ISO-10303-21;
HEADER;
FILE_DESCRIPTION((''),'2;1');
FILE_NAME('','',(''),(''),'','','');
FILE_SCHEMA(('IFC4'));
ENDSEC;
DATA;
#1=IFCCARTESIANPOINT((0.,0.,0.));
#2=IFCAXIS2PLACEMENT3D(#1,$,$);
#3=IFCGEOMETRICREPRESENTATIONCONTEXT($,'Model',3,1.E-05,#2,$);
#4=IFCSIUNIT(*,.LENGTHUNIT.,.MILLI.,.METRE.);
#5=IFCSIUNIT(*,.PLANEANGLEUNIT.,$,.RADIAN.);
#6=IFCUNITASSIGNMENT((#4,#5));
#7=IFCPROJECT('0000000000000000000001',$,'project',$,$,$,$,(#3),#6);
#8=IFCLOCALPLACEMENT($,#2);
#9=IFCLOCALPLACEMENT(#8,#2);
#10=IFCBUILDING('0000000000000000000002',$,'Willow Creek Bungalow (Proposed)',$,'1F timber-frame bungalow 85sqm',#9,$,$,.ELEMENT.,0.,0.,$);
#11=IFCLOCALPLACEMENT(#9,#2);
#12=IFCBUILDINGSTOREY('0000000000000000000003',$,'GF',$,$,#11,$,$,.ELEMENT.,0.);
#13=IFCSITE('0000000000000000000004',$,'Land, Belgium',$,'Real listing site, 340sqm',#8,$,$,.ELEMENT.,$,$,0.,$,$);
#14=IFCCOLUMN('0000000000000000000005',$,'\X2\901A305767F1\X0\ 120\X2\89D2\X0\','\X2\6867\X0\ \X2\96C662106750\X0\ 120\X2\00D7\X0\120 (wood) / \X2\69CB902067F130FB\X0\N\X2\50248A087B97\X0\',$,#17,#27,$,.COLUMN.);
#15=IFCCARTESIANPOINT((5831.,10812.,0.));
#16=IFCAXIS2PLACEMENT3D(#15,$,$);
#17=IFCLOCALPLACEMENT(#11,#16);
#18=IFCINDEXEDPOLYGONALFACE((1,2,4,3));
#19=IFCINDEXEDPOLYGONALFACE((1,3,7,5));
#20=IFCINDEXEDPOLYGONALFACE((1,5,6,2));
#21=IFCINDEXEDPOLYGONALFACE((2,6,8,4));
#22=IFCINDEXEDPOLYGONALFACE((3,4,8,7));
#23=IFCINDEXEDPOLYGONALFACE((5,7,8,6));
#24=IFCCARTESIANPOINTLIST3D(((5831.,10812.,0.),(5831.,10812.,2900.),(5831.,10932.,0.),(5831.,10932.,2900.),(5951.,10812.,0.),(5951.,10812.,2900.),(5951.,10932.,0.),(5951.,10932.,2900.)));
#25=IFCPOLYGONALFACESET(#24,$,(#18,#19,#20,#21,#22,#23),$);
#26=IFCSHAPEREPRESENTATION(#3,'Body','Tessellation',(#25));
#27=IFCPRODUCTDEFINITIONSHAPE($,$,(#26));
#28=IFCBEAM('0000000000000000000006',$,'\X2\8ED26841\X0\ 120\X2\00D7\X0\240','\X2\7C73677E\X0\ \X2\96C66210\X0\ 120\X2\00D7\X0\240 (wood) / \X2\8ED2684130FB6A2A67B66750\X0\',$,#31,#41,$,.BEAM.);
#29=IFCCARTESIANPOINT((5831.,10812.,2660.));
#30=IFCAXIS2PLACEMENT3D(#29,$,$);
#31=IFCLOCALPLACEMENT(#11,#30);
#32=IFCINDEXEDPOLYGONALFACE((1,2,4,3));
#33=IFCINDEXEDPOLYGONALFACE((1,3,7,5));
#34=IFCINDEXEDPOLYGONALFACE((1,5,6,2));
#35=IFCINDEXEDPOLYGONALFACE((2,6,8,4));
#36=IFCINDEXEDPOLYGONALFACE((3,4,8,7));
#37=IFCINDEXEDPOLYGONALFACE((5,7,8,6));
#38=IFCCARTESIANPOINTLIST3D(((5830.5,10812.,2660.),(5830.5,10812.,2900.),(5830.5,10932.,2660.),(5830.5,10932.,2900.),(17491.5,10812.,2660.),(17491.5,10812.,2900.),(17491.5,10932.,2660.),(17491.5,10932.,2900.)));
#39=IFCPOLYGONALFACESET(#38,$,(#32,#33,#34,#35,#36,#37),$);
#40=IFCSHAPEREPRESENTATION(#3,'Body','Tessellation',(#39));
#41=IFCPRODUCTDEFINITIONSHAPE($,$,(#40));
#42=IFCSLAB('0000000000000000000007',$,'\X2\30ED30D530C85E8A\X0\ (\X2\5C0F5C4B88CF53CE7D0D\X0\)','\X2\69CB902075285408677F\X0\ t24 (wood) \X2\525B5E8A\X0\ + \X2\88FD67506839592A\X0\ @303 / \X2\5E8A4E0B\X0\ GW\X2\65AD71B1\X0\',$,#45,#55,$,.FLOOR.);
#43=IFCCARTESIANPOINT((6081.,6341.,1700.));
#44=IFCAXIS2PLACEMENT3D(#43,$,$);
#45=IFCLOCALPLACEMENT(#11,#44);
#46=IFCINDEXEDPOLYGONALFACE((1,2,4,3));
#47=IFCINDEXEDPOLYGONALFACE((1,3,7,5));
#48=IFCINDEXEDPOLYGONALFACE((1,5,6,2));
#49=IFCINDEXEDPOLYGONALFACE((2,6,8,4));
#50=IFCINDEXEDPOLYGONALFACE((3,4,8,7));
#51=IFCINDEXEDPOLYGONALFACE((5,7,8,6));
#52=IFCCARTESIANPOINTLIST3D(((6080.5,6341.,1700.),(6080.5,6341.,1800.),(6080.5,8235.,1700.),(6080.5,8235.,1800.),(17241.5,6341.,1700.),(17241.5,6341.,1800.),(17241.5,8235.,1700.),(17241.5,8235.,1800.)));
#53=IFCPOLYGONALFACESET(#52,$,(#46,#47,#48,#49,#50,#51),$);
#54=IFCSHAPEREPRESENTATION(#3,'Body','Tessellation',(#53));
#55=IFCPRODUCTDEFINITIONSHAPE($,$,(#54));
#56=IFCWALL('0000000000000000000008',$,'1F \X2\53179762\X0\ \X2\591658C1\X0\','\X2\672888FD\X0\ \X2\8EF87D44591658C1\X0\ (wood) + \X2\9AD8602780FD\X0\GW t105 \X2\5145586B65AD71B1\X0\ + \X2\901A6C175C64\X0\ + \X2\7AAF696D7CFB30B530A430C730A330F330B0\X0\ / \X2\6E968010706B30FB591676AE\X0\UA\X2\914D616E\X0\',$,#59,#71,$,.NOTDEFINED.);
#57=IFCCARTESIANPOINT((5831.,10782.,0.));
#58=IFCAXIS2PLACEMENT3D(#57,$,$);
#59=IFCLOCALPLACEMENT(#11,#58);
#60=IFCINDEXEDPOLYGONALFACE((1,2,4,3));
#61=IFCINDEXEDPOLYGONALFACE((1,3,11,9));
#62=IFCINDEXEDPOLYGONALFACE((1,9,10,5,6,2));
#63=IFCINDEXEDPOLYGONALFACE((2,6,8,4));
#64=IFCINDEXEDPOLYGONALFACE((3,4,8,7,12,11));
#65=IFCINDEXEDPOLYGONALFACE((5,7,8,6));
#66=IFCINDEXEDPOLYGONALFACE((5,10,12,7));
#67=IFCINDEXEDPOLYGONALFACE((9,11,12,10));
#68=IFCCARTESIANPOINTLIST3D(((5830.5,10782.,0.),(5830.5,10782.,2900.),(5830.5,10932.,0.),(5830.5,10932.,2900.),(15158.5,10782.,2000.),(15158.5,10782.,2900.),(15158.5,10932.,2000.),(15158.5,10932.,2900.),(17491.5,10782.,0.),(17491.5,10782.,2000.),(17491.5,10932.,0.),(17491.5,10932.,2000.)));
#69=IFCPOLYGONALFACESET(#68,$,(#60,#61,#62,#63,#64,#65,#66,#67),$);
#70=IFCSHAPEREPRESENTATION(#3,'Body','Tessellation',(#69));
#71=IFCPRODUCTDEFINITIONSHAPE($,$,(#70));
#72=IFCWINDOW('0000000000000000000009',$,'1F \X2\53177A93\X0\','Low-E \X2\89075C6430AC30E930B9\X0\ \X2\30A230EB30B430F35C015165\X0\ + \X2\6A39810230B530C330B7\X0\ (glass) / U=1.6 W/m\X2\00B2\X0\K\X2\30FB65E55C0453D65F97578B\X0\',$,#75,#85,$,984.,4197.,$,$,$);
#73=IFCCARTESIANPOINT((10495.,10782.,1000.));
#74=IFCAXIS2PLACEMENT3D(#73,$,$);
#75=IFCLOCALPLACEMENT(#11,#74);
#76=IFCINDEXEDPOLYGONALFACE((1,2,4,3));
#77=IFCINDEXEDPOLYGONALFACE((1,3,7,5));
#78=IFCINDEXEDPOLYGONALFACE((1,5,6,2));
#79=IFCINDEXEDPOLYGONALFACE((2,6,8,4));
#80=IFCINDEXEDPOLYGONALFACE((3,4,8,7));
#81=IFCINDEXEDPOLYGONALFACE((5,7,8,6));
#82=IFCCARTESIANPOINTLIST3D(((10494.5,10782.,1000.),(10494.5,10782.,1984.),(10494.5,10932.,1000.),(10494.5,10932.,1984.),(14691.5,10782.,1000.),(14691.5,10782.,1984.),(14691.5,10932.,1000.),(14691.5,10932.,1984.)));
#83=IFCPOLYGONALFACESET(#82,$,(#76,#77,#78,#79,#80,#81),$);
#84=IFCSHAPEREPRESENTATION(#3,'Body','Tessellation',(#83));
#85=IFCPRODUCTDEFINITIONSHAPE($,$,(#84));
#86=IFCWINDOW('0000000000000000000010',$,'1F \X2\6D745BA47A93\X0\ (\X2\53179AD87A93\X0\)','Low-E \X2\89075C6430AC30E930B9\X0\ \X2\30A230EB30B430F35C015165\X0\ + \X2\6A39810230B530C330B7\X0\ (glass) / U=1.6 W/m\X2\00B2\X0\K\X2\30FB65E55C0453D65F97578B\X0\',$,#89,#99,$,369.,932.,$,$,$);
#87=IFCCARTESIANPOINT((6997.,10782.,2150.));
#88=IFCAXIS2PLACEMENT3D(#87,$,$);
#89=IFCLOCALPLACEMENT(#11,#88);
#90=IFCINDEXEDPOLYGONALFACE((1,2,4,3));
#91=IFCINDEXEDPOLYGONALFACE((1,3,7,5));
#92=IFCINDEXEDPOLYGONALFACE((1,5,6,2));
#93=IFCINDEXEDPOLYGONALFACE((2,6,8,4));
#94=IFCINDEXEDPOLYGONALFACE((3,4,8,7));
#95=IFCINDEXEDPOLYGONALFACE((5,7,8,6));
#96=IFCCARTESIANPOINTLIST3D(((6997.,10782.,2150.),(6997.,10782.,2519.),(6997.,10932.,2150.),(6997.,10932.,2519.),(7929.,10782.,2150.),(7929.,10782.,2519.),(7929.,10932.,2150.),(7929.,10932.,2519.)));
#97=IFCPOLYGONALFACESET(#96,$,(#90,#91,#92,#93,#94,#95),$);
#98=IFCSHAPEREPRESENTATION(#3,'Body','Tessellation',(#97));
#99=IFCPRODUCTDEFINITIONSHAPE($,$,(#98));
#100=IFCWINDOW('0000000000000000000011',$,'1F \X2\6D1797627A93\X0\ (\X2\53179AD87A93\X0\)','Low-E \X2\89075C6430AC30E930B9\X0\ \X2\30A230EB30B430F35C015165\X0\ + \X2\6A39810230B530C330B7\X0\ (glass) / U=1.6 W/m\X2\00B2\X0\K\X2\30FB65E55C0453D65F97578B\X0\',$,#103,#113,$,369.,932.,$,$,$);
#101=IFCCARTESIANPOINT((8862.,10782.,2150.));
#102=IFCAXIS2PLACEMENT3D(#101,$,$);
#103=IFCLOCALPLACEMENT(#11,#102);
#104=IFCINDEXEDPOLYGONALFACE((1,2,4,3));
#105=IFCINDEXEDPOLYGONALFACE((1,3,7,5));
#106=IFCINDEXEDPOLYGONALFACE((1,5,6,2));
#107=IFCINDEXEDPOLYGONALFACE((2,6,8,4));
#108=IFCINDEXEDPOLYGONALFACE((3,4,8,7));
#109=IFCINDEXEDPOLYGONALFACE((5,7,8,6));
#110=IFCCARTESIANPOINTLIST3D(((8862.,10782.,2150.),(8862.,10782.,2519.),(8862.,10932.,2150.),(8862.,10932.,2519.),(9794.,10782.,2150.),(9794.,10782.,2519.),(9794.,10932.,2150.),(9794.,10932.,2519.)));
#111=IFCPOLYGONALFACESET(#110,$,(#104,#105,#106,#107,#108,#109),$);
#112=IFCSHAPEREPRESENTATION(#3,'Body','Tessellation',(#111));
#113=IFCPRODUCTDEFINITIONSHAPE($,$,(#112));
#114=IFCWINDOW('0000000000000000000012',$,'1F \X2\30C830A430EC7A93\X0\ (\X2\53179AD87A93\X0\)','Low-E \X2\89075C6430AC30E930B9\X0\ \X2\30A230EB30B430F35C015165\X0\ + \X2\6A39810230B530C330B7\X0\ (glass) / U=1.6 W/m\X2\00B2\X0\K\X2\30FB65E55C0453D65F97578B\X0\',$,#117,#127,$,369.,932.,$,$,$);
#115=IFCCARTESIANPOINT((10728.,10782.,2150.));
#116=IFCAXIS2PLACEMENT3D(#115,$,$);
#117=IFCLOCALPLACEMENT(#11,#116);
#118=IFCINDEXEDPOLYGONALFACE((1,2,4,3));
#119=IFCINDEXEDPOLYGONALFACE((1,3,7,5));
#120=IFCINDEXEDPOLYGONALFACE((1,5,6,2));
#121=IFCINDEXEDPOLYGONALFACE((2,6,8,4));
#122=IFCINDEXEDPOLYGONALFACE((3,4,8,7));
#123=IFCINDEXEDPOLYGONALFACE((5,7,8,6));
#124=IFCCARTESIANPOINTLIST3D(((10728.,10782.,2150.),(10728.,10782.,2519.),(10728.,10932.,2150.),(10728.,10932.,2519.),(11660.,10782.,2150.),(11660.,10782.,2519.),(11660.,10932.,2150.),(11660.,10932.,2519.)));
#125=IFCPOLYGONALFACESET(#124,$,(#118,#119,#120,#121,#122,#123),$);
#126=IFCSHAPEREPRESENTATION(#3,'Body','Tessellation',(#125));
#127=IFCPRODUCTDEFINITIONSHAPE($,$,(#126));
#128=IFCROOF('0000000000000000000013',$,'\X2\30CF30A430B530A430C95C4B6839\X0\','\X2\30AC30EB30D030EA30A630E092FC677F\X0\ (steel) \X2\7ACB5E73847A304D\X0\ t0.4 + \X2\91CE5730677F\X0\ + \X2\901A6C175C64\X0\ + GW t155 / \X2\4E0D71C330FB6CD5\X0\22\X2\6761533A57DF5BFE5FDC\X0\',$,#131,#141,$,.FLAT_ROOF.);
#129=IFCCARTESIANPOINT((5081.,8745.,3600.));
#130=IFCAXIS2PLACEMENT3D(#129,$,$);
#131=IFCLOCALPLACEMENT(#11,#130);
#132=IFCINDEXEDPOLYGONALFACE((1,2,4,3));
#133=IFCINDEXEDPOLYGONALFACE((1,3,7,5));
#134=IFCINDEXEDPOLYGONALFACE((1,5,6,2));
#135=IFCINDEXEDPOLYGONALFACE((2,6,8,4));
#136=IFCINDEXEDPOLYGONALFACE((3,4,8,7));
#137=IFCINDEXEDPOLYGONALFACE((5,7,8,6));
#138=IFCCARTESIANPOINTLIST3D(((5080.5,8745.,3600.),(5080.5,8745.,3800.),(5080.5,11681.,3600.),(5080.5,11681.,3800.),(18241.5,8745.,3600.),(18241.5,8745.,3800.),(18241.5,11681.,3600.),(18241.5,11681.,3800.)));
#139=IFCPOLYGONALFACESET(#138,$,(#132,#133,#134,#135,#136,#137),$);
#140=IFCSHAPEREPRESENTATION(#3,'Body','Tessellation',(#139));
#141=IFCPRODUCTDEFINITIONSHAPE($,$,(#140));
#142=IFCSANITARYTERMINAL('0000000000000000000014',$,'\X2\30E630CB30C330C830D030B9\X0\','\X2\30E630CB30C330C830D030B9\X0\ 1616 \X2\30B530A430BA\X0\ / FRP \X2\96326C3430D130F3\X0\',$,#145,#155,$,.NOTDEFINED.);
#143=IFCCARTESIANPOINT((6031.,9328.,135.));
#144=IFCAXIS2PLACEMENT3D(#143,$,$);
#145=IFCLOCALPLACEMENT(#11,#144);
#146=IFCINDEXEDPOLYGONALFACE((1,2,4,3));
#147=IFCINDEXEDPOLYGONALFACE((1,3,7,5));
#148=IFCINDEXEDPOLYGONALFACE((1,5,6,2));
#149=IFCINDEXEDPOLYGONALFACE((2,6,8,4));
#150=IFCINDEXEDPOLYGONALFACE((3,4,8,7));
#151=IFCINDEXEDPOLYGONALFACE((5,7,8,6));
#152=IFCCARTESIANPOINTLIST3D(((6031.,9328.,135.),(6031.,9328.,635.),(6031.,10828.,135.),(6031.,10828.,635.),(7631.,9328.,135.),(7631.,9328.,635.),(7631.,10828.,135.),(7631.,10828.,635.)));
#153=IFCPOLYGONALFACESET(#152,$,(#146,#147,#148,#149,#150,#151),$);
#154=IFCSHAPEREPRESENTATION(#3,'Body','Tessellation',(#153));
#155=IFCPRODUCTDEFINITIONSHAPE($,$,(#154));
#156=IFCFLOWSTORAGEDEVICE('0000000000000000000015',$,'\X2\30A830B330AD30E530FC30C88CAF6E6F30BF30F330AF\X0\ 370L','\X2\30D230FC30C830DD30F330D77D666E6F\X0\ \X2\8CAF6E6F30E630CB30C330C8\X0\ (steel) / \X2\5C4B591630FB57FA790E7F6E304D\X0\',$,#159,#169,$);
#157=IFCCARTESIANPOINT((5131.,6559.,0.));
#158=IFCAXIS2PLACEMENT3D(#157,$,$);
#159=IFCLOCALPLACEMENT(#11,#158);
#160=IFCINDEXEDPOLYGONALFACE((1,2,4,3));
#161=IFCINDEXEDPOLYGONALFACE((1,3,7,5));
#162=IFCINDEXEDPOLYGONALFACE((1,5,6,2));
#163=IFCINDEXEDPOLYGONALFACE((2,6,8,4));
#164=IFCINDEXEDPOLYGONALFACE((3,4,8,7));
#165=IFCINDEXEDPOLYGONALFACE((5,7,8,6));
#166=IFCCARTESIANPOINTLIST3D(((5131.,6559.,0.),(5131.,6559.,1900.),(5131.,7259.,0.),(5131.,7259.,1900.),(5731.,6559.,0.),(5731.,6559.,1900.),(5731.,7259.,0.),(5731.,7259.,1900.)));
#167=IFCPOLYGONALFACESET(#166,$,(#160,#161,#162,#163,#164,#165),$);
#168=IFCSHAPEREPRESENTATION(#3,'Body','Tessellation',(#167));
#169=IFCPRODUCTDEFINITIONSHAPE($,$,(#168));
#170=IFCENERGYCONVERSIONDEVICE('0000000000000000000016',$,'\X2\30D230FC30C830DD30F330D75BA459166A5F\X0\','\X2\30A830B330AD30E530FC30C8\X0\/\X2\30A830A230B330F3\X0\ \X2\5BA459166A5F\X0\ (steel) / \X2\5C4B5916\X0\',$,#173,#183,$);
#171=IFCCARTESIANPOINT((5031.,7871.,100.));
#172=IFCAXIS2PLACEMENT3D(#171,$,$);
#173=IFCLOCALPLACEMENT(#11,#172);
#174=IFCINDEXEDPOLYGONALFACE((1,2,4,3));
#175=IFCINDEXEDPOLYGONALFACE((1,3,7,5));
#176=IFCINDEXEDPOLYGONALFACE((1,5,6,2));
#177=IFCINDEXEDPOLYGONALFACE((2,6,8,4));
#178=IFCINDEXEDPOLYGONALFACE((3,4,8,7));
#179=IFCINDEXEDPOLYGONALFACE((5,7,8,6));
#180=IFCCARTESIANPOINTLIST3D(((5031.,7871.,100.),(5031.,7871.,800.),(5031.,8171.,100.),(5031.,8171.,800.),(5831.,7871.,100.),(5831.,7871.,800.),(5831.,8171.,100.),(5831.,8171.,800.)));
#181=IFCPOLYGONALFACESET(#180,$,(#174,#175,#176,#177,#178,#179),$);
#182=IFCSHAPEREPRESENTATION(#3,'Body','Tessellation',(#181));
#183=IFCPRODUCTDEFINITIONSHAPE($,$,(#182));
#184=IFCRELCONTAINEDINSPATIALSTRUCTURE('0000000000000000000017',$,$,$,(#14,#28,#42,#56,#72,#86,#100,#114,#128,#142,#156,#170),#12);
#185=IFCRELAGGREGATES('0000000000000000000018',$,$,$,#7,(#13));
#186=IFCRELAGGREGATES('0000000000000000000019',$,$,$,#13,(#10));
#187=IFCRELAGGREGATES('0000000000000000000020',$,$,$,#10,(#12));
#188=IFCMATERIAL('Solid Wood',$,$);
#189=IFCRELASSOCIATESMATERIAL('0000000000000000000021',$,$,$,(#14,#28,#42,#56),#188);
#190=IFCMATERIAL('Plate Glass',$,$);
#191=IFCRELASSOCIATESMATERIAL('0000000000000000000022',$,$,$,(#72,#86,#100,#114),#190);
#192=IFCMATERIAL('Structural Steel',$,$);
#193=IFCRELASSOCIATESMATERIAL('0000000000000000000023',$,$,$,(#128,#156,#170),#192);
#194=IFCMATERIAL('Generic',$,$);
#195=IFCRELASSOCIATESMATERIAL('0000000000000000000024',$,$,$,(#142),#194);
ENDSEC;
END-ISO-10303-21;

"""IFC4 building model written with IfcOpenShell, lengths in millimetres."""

from ifc_helpers import new_model, si_unit, frame, frame_2d, origin, place, context, project, spatial, rectangle, extrude, material, element, fill, save


model = new_model("IFC4")

# Units and contexts
model_context = context("Model", 3, precision=1e-05, world=origin())
ifc_project = project(units=[si_unit("LENGTHUNIT", "METRE", prefix="MILLI"), si_unit("PLANEANGLEUNIT", "RADIAN")], contexts=[model_context])

# Site, building, storey
site_placement = place(None, origin())
site = spatial("IfcSite", under=ifc_project, at=site_placement, Name="Land, Belgium", ObjectType="Real listing site, 340sqm", CompositionType="ELEMENT", RefElevation=0.0)
building_placement = place(site_placement, origin())
building = spatial("IfcBuilding", under=site, at=building_placement, Name="Willow Creek Bungalow (Proposed)", ObjectType="1F timber-frame bungalow 85sqm", CompositionType="ELEMENT", ElevationOfRefHeight=0.0, ElevationOfTerrain=0.0)
storey_placement = place(building_placement, origin())
storey = spatial("IfcBuildingStorey", under=building, at=storey_placement, Name="GF", CompositionType="ELEMENT", Elevation=0.0)

# Column
ifc_material_1 = material(Name="Solid Wood")
column_1_placement = place(storey_placement, frame((5831.0, 10812.0, 0.0)))
element("IfcColumn", 1, at=column_1_placement, inside=storey, material=ifc_material_1, Name="通し柱 120角", Description="桧 集成材 120×120 (wood) / 構造柱・N値計算", PredefinedType="COLUMN", context=model_context, shape_type="SweptSolid", body=[
    extrude(rectangle(XDim=120.0, YDim=120.0, at=frame_2d((60.0, 60.0))), frame((5831.0, 10812.0, 0.0)), (0.0, 0.0, 1.0), 2900.0),
])

# Beam
beam_1_placement = place(storey_placement, frame((5831.0, 10812.0, 2660.0)))
element("IfcBeam", 2, at=beam_1_placement, inside=storey, material=ifc_material_1, Name="軒桁 120×240", Description="米松 集成 120×240 (wood) / 軒桁・横架材", PredefinedType="BEAM", context=model_context, shape_type="SweptSolid", body=[
    extrude(rectangle(XDim=11661.0, YDim=120.0, at=frame_2d((5830.0, 60.0))), frame((5831.0, 10812.0, 2660.0)), (0.0, 0.0, 1.0), 240.0),
])

# Slab
slab_placement = place(storey_placement, frame((6081.0, 6341.0, 1700.0)))
element("IfcSlab", 3, at=slab_placement, inside=storey, material=ifc_material_1, Name="ロフト床 (小屋裏収納)", Description="構造用合板 t24 (wood) 剛床 + 製材根太 @303 / 床下 GW断熱", PredefinedType="FLOOR", context=model_context, shape_type="SweptSolid", body=[
    extrude(rectangle(XDim=11161.0, YDim=1894.0, at=frame_2d((5580.0, 947.0))), frame((6081.0, 6341.0, 1700.0)), (0.0, 0.0, 1.0), 100.0),
])

# Wall, openings, windows
wall_1_placement = place(storey_placement, frame((5831.0, 10782.0, 0.0)))
wall_1 = element("IfcWall", 4, at=wall_1_placement, inside=storey, material=ifc_material_1, Name="1F 北面 外壁", Description="木製 軸組外壁 (wood) + 高性能GW t105 充填断熱 + 通気層 + 窯業系サイディング / 準耐火・外皮UA配慮", PredefinedType="NOTDEFINED", context=model_context, shape_type="SweptSolid", body=[
    extrude(rectangle(XDim=11661.0, YDim=150.0, at=frame_2d((5830.0, 75.0))), frame((5831.0, 10782.0, 0.0)), (0.0, 0.0, 1.0), 2900.0),
])
opening_1_placement = place(storey_placement, frame((10495.0, 10782.0, 1000.0)))
opening_1 = element("IfcOpeningElement", 5, at=opening_1_placement, cuts=wall_1, PredefinedType="NOTDEFINED", context=model_context, shape_type="SweptSolid", body=[
    extrude(rectangle(XDim=4197.0, YDim=150.0, at=frame_2d((2098.0, 75.0))), frame((10495.0, 10782.0, 1000.0)), (0.0, 0.0, 1.0), 984.0),
])
opening_2_placement = place(storey_placement, frame((6997.0, 10782.0, 2150.0)))
opening_2 = element("IfcOpeningElement", 6, at=opening_2_placement, cuts=wall_1, PredefinedType="NOTDEFINED", context=model_context, shape_type="SweptSolid", body=[
    extrude(rectangle(XDim=932.0, YDim=150.0, at=frame_2d((466.0, 75.0))), frame((6997.0, 10782.0, 2150.0)), (0.0, 0.0, 1.0), 369.0),
])
opening_3_placement = place(storey_placement, frame((8862.0, 10782.0, 2150.0)))
opening_3 = element("IfcOpeningElement", 7, at=opening_3_placement, cuts=wall_1, PredefinedType="NOTDEFINED", context=model_context, shape_type="SweptSolid", body=[
    extrude(rectangle(XDim=932.0, YDim=150.0, at=frame_2d((466.0, 75.0))), frame((8862.0, 10782.0, 2150.0)), (0.0, 0.0, 1.0), 369.0),
])
opening_4_placement = place(storey_placement, frame((10728.0, 10782.0, 2150.0)))
opening_4 = element("IfcOpeningElement", 8, at=opening_4_placement, cuts=wall_1, PredefinedType="NOTDEFINED", context=model_context, shape_type="SweptSolid", body=[
    extrude(rectangle(XDim=932.0, YDim=150.0, at=frame_2d((466.0, 75.0))), frame((10728.0, 10782.0, 2150.0)), (0.0, 0.0, 1.0), 369.0),
])
ifc_material_2 = material(Name="Plate Glass")
window_1_placement = place(storey_placement, frame((10495.0, 10782.0, 1000.0)))
window_1 = element("IfcWindow", 9, at=window_1_placement, inside=storey, material=ifc_material_2, Name="1F 北窓", Description="Low-E 複層ガラス アルゴン封入 + 樹脂サッシ (glass) / U=1.6 W/m²K・日射取得型", OverallHeight=984.0, OverallWidth=4197.0, context=model_context, shape_type="SweptSolid", body=[
    extrude(rectangle(XDim=4197.0, YDim=150.0, at=frame_2d((2098.0, 75.0))), frame((10495.0, 10782.0, 1000.0)), (0.0, 0.0, 1.0), 984.0),
])
fill(opening_1, window_1)
window_2_placement = place(storey_placement, frame((6997.0, 10782.0, 2150.0)))
window_2 = element("IfcWindow", 10, at=window_2_placement, inside=storey, material=ifc_material_2, Name="1F 浴室窓 (北高窓)", Description="Low-E 複層ガラス アルゴン封入 + 樹脂サッシ (glass) / U=1.6 W/m²K・日射取得型", OverallHeight=369.0, OverallWidth=932.0, context=model_context, shape_type="SweptSolid", body=[
    extrude(rectangle(XDim=932.0, YDim=150.0, at=frame_2d((466.0, 75.0))), frame((6997.0, 10782.0, 2150.0)), (0.0, 0.0, 1.0), 369.0),
])
fill(opening_2, window_2)
window_3_placement = place(storey_placement, frame((8862.0, 10782.0, 2150.0)))
window_3 = element("IfcWindow", 11, at=window_3_placement, inside=storey, material=ifc_material_2, Name="1F 洗面窓 (北高窓)", Description="Low-E 複層ガラス アルゴン封入 + 樹脂サッシ (glass) / U=1.6 W/m²K・日射取得型", OverallHeight=369.0, OverallWidth=932.0, context=model_context, shape_type="SweptSolid", body=[
    extrude(rectangle(XDim=932.0, YDim=150.0, at=frame_2d((466.0, 75.0))), frame((8862.0, 10782.0, 2150.0)), (0.0, 0.0, 1.0), 369.0),
])
fill(opening_3, window_3)
window_4_placement = place(storey_placement, frame((10728.0, 10782.0, 2150.0)))
window_4 = element("IfcWindow", 12, at=window_4_placement, inside=storey, material=ifc_material_2, Name="1F トイレ窓 (北高窓)", Description="Low-E 複層ガラス アルゴン封入 + 樹脂サッシ (glass) / U=1.6 W/m²K・日射取得型", OverallHeight=369.0, OverallWidth=932.0, context=model_context, shape_type="SweptSolid", body=[
    extrude(rectangle(XDim=932.0, YDim=150.0, at=frame_2d((466.0, 75.0))), frame((10728.0, 10782.0, 2150.0)), (0.0, 0.0, 1.0), 369.0),
])
fill(opening_4, window_4)

# Roof
ifc_material_3 = material(Name="Structural Steel")
roof_placement = place(storey_placement, frame((5081.0, 8745.0, 3600.0)))
element("IfcRoof", 13, at=roof_placement, inside=storey, material=ifc_material_3, Name="ハイサイド屋根", Description="ガルバリウム鋼板 (steel) 立平葺き t0.4 + 野地板 + 通気層 + GW t155 / 不燃・法22条区域対応", PredefinedType="FLAT_ROOF", context=model_context, shape_type="SweptSolid", body=[
    extrude(rectangle(XDim=13161.0, YDim=2936.0, at=frame_2d((6580.0, 1468.0))), frame((5081.0, 8745.0, 3600.0)), (0.0, 0.0, 1.0), 200.0),
])

# Sanitary terminal
ifc_material_4 = material(Name="Generic")
sanitary_terminal_placement = place(storey_placement, frame((6031.0, 9328.0, 135.0)))
element("IfcSanitaryTerminal", 14, at=sanitary_terminal_placement, inside=storey, material=ifc_material_4, Name="ユニットバス", Description="ユニットバス 1616 サイズ / FRP 防水パン", PredefinedType="NOTDEFINED", context=model_context, shape_type="SweptSolid", body=[
    extrude(rectangle(XDim=1600.0, YDim=1500.0, at=frame_2d((800.0, 750.0))), frame((6031.0, 9328.0, 135.0)), (0.0, 0.0, 1.0), 500.0),
])

# Flow storage device
flow_storage_device_placement = place(storey_placement, frame((5131.0, 6559.0, 0.0)))
element("IfcFlowStorageDevice", 15, at=flow_storage_device_placement, inside=storey, material=ifc_material_3, Name="エコキュート貯湯タンク 370L", Description="ヒートポンプ給湯 貯湯ユニット (steel) / 屋外・基礎置き", context=model_context, shape_type="SweptSolid", body=[
    extrude(rectangle(XDim=600.0, YDim=700.0, at=frame_2d((300.0, 350.0))), frame((5131.0, 6559.0, 0.0)), (0.0, 0.0, 1.0), 1900.0),
])

# Energy conversion device
energy_conversion_device_placement = place(storey_placement, frame((5031.0, 7871.0, 100.0)))
element("IfcEnergyConversionDevice", 16, at=energy_conversion_device_placement, inside=storey, material=ifc_material_3, Name="ヒートポンプ室外機", Description="エコキュート/エアコン 室外機 (steel) / 屋外", context=model_context, shape_type="SweptSolid", body=[
    extrude(rectangle(XDim=800.0, YDim=300.0, at=frame_2d((400.0, 150.0))), frame((5031.0, 7871.0, 100.0)), (0.0, 0.0, 1.0), 700.0),
])

save(model, "model.ifc")
